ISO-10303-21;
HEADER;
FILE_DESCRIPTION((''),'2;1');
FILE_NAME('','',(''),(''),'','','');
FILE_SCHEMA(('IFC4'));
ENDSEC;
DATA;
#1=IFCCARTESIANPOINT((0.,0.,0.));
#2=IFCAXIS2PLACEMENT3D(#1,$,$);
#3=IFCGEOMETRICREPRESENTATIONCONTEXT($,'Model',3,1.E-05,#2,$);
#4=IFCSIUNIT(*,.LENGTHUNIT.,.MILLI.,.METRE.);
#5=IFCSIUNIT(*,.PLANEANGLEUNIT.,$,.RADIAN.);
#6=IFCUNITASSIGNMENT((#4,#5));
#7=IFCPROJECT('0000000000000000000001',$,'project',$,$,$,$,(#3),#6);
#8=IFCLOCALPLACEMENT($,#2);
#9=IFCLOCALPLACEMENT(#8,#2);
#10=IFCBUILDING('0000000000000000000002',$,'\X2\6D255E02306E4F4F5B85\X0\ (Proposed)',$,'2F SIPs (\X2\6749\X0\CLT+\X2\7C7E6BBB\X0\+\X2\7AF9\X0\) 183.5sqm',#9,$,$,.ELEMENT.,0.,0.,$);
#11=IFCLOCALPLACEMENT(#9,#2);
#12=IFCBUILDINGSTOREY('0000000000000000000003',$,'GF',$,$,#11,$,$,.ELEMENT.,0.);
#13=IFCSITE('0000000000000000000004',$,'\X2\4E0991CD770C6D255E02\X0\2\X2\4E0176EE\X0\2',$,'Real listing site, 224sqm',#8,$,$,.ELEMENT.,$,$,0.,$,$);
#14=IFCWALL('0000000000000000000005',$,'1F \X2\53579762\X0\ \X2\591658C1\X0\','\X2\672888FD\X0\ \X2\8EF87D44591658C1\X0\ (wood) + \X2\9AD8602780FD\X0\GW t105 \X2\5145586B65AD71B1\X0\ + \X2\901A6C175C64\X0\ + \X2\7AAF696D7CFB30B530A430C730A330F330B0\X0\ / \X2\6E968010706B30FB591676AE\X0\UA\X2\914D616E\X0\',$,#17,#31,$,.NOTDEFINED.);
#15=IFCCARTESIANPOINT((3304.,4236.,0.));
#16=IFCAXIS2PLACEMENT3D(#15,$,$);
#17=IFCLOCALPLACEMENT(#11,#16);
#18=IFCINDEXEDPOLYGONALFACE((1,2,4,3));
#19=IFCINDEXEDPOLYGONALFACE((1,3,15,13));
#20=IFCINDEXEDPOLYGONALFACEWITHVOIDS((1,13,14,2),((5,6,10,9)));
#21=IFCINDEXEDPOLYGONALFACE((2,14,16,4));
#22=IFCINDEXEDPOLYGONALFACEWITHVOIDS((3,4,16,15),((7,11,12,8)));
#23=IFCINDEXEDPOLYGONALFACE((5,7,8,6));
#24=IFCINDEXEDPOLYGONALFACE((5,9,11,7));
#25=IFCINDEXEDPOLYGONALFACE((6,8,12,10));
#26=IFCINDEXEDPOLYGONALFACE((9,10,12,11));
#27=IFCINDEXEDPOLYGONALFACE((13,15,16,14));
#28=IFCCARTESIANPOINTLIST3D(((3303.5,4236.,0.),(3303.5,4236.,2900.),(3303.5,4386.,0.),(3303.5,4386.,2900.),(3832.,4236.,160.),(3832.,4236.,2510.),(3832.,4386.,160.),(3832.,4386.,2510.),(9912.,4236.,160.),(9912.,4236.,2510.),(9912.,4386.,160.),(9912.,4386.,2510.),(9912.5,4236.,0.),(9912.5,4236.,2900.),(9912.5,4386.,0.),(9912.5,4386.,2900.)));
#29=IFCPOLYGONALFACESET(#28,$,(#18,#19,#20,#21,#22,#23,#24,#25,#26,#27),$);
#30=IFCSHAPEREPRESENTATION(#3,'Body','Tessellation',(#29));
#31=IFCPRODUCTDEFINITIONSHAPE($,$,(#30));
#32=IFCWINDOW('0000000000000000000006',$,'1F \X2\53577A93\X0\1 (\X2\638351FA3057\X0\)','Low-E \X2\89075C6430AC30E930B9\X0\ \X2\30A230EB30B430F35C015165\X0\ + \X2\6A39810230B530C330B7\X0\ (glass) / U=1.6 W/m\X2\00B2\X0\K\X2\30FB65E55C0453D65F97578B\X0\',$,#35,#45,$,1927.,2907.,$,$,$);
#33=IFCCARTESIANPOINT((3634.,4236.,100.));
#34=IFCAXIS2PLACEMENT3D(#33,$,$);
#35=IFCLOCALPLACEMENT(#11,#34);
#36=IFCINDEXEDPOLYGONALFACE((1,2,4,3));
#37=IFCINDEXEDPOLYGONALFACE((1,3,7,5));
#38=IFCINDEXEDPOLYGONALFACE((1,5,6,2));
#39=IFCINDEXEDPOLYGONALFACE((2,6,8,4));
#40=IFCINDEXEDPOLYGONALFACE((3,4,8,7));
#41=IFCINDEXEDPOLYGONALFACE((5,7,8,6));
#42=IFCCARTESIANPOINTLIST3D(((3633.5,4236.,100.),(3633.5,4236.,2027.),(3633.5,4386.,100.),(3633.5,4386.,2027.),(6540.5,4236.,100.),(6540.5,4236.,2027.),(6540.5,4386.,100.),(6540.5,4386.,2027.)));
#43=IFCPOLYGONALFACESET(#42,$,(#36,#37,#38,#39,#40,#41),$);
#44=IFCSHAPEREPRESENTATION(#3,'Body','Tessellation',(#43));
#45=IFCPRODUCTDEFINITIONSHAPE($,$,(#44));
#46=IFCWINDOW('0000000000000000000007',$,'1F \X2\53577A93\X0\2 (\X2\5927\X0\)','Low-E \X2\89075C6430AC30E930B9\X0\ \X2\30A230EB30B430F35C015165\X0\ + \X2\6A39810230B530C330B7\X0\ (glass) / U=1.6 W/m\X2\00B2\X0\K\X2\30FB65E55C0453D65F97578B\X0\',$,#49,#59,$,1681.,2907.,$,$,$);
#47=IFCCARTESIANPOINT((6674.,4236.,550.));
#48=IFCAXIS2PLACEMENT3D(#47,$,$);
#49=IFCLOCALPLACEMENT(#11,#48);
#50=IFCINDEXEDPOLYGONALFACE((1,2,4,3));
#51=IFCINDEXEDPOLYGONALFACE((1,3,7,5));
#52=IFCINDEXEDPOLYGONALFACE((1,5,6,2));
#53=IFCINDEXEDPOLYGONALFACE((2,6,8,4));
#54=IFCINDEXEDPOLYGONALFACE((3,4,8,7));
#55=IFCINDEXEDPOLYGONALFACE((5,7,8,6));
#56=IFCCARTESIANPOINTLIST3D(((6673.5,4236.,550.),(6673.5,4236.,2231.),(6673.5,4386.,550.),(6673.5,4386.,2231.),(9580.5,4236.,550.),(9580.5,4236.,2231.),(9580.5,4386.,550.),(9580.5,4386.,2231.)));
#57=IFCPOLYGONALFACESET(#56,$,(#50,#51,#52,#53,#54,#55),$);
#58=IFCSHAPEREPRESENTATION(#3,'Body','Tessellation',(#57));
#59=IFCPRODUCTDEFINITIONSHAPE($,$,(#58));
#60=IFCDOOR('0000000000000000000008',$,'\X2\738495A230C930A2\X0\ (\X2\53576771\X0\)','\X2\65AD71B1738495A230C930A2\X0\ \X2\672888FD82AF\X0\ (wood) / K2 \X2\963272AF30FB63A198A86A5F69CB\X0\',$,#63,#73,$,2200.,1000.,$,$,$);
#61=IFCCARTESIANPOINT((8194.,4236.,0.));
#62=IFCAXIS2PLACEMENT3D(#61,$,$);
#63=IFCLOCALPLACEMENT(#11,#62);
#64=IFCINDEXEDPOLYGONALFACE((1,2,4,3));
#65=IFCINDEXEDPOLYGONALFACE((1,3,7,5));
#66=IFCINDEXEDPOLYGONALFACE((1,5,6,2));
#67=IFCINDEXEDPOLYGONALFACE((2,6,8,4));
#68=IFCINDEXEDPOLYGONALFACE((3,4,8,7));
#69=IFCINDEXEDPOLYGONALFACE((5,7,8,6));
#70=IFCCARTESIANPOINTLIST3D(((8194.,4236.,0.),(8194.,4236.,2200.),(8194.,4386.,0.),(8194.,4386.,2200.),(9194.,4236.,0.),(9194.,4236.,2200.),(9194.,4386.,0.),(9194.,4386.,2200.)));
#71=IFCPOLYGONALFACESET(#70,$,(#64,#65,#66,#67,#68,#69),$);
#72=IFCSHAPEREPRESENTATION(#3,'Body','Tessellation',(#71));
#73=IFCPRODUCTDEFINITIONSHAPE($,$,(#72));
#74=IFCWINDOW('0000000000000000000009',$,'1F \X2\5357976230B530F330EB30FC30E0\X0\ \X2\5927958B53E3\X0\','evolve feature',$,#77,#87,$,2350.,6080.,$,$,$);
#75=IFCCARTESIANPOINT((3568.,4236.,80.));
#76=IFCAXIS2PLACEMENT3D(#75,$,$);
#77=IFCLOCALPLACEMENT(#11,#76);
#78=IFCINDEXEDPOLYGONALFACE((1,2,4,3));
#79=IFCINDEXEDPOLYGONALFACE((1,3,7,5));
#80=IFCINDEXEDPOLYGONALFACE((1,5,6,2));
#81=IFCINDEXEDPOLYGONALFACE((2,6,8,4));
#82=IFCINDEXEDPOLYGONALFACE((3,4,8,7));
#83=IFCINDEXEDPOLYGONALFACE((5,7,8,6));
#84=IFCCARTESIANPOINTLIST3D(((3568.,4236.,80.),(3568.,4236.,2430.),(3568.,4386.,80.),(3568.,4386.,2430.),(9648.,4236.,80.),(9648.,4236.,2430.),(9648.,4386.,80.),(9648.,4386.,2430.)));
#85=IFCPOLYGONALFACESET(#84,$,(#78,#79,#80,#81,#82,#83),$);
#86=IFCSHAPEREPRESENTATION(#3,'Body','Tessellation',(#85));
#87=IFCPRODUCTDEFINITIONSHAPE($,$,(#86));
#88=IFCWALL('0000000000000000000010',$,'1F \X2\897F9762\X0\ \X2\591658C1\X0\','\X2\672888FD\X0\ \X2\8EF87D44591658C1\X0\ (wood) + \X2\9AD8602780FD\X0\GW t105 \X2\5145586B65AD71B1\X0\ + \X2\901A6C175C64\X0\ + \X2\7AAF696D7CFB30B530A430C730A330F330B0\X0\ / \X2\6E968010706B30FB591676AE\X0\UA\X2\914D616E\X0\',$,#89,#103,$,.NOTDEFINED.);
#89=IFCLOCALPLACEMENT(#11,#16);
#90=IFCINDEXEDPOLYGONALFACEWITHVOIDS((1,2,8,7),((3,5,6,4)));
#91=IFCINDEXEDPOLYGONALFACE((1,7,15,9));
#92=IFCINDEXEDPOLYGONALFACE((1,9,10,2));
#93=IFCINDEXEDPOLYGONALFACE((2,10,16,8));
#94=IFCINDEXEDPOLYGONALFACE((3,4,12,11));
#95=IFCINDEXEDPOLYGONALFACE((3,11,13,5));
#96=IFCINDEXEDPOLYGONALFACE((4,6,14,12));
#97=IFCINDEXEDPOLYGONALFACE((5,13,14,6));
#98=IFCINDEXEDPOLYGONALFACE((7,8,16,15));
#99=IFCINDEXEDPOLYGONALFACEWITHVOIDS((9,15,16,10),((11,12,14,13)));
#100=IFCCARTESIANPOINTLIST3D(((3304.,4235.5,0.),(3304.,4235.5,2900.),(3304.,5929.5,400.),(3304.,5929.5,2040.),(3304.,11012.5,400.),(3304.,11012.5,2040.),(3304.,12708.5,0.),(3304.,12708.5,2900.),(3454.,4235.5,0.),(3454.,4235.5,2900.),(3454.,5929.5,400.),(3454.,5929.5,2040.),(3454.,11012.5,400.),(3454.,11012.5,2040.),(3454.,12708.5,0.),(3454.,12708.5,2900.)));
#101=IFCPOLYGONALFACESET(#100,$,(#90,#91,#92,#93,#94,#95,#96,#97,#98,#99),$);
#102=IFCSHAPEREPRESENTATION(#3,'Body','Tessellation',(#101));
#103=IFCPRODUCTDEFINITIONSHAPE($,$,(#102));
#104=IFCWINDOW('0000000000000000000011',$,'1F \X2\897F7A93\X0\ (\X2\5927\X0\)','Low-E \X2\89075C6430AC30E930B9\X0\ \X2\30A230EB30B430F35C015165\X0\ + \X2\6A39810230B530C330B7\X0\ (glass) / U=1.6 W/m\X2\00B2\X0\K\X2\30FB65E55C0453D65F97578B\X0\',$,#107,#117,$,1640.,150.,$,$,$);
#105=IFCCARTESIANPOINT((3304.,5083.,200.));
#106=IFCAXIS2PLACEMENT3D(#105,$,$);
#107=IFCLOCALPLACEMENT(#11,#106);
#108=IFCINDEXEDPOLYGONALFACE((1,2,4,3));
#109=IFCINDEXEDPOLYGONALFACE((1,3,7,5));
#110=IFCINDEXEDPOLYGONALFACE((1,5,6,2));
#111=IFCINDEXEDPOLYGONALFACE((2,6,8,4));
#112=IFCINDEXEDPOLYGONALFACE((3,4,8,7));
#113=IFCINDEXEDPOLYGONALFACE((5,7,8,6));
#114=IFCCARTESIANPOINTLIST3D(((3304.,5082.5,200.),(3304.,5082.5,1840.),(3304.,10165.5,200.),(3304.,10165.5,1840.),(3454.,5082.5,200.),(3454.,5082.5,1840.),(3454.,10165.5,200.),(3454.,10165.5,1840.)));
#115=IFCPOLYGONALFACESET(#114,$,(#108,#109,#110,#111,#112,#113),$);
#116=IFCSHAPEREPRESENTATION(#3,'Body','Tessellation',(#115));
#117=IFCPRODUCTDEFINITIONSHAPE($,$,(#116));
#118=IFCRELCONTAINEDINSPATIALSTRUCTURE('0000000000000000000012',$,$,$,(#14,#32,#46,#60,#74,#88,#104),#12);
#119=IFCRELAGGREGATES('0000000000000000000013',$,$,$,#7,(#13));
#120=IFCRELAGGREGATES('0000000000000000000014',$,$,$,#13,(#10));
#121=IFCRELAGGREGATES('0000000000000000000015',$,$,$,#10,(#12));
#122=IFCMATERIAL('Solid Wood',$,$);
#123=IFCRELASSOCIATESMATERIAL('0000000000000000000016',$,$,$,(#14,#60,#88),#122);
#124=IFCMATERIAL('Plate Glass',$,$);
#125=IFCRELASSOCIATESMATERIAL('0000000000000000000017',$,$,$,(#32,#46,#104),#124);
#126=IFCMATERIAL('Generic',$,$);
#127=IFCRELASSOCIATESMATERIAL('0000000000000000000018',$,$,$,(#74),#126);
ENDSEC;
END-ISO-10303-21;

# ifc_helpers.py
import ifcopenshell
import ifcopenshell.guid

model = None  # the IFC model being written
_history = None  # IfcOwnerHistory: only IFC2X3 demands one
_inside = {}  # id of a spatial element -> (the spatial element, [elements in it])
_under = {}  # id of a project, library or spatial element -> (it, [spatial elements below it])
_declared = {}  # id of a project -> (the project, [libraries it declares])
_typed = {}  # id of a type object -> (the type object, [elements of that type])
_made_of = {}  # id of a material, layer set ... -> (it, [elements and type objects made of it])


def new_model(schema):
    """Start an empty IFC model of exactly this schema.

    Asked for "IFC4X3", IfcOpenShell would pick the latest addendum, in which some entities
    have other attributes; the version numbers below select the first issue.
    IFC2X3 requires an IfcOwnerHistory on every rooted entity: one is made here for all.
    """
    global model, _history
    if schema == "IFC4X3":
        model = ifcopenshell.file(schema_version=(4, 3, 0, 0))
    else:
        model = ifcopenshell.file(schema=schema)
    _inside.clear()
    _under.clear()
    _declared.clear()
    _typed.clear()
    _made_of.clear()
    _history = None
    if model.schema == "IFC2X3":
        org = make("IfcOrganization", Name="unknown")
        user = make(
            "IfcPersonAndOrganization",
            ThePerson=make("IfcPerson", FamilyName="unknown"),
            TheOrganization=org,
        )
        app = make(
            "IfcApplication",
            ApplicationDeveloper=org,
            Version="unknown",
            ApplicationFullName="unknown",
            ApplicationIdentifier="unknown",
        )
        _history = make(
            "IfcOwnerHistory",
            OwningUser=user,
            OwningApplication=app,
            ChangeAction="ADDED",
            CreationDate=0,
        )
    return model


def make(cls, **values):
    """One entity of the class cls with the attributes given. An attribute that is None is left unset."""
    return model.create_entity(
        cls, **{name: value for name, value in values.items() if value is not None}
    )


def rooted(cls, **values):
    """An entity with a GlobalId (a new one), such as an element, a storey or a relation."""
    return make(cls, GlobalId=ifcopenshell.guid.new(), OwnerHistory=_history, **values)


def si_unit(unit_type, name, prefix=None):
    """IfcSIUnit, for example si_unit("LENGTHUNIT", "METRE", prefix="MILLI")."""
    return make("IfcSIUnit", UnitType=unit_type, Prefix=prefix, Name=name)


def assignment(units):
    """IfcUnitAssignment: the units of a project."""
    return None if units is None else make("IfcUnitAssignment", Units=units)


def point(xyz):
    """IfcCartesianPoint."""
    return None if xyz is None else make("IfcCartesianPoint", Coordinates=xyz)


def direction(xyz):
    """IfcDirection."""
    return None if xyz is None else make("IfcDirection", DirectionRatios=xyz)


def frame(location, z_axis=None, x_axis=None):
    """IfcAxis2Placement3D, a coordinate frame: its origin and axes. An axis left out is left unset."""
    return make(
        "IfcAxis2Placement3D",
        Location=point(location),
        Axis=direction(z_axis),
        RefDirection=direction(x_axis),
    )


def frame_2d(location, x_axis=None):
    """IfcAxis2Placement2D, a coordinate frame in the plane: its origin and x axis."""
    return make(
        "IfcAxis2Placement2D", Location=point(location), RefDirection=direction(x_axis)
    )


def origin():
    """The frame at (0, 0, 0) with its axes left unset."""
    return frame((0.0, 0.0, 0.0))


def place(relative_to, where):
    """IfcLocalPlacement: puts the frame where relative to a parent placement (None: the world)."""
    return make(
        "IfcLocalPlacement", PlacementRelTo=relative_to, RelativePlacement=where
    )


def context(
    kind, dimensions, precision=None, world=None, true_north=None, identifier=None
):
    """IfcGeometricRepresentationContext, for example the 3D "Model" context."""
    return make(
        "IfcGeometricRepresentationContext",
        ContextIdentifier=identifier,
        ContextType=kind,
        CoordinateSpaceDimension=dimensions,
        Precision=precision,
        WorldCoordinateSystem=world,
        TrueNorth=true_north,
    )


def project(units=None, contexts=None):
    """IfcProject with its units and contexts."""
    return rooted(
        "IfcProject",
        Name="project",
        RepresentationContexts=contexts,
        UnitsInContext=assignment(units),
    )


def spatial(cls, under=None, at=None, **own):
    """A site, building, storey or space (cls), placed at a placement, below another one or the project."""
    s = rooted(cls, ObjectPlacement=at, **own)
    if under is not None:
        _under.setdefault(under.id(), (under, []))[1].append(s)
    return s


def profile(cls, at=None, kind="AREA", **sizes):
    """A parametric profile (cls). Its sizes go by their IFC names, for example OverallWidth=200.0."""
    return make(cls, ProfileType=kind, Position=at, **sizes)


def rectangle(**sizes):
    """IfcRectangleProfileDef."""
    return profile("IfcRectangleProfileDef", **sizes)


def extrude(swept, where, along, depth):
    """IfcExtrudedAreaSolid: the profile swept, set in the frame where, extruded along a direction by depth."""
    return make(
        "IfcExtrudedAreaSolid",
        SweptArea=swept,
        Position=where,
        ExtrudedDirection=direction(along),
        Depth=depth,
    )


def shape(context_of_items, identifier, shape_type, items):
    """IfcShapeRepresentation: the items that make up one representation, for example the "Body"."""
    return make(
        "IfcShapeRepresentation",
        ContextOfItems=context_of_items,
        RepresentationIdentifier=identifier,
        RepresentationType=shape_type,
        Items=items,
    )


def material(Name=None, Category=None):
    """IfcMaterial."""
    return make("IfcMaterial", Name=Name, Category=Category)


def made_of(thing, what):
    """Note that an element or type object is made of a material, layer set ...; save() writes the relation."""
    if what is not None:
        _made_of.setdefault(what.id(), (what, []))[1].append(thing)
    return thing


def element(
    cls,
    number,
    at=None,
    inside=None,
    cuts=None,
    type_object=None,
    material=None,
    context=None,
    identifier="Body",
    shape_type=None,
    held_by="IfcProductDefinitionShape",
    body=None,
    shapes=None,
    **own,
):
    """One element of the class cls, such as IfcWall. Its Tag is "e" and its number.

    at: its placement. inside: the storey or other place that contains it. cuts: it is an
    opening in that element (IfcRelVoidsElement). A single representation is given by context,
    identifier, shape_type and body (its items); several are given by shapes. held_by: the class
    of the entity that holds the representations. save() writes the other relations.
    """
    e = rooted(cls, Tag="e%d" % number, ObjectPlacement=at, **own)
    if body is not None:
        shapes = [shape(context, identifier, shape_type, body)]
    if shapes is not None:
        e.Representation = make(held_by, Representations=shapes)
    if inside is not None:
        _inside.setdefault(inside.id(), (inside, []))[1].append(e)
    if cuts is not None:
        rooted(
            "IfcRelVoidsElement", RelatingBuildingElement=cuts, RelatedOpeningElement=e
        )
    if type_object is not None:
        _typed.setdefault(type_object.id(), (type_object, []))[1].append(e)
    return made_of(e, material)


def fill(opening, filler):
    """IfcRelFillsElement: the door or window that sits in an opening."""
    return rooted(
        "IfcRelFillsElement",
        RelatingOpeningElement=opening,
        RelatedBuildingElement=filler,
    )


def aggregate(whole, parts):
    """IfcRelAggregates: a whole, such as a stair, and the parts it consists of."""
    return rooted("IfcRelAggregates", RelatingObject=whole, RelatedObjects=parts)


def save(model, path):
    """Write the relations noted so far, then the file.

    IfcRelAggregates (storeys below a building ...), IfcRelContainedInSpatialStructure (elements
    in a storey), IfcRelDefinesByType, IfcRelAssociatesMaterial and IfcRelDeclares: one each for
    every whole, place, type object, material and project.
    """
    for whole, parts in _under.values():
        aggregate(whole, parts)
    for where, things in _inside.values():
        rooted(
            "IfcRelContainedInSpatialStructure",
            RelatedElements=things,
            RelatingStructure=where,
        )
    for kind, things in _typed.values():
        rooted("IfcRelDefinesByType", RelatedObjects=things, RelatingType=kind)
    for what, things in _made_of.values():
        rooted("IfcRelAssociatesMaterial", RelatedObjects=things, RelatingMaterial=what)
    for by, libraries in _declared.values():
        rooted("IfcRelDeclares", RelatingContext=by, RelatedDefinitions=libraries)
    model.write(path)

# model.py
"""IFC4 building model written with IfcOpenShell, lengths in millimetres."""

from ifc_helpers import new_model, si_unit, frame, frame_2d, origin, place, context, project, spatial, rectangle, extrude, material, element, fill, save


model = new_model("IFC4")

# Units and contexts
model_context = context("Model", 3, precision=1e-05, world=origin())
ifc_project = project(units=[si_unit("LENGTHUNIT", "METRE", prefix="MILLI"), si_unit("PLANEANGLEUNIT", "RADIAN")], contexts=[model_context])

# Site, building, storey
site_placement = place(None, origin())
site = spatial("IfcSite", under=ifc_project, at=site_placement, Name="三重県津市2丁目2", ObjectType="Real listing site, 224sqm", CompositionType="ELEMENT", RefElevation=0.0)
building_placement = place(site_placement, origin())
building = spatial("IfcBuilding", under=site, at=building_placement, Name="津市の住宅 (Proposed)", ObjectType="2F SIPs (杉CLT+籾殻+竹) 183.5sqm", CompositionType="ELEMENT", ElevationOfRefHeight=0.0, ElevationOfTerrain=0.0)
storey_placement = place(building_placement, origin())
storey = spatial("IfcBuildingStorey", under=building, at=storey_placement, Name="GF", CompositionType="ELEMENT", Elevation=0.0)

# Shared definitions
ifc_material_1 = material(Name="Solid Wood")
ifc_material_2 = material(Name="Generic")

# Wall, openings, windows, door
wall_1_placement = place(storey_placement, frame((3304.0, 4236.0, 0.0)))
wall_1 = element("IfcWall", 1, at=wall_1_placement, inside=storey, material=ifc_material_1, Name="1F 南面 外壁", Description="木製 軸組外壁 (wood) + 高性能GW t105 充填断熱 + 通気層 + 窯業系サイディング / 準耐火・外皮UA配慮", PredefinedType="NOTDEFINED", context=model_context, shape_type="SweptSolid", body=[
    extrude(rectangle(XDim=6609.0, YDim=150.0, at=frame_2d((3304.0, 75.0))), frame((3304.0, 4236.0, 0.0)), (0.0, 0.0, 1.0), 2900.0),
])
opening_1_placement = place(storey_placement, frame((3634.0, 4236.0, 100.0)))
opening_1 = element("IfcOpeningElement", 2, at=opening_1_placement, cuts=wall_1, PredefinedType="NOTDEFINED", context=model_context, shape_type="SweptSolid", body=[
    extrude(rectangle(XDim=2907.0, YDim=150.0, at=frame_2d((1453.0, 75.0))), frame((3634.0, 4236.0, 100.0)), (0.0, 0.0, 1.0), 1927.0),
])
opening_2_placement = place(storey_placement, frame((6674.0, 4236.0, 550.0)))
opening_2 = element("IfcOpeningElement", 3, at=opening_2_placement, cuts=wall_1, PredefinedType="NOTDEFINED", context=model_context, shape_type="SweptSolid", body=[
    extrude(rectangle(XDim=2907.0, YDim=150.0, at=frame_2d((1453.0, 75.0))), frame((6674.0, 4236.0, 550.0)), (0.0, 0.0, 1.0), 1681.0),
])
opening_3_placement = place(storey_placement, frame((8194.0, 4236.0, 0.0)))
opening_3 = element("IfcOpeningElement", 4, at=opening_3_placement, cuts=wall_1, PredefinedType="NOTDEFINED", context=model_context, shape_type="SweptSolid", body=[
    extrude(rectangle(XDim=1000.0, YDim=150.0, at=frame_2d((500.0, 75.0))), frame((8194.0, 4236.0, 0.0)), (0.0, 0.0, 1.0), 2200.0),
])
opening_4_placement = place(storey_placement, frame((3568.0, 4236.0, 80.0)))
opening_4 = element("IfcOpeningElement", 5, at=opening_4_placement, cuts=wall_1, PredefinedType="NOTDEFINED", context=model_context, shape_type="SweptSolid", body=[
    extrude(rectangle(XDim=6080.0, YDim=150.0, at=frame_2d((3040.0, 75.0))), frame((3568.0, 4236.0, 80.0)), (0.0, 0.0, 1.0), 2350.0),
])
ifc_material_3 = material(Name="Plate Glass")
window_1_placement = place(storey_placement, frame((3634.0, 4236.0, 100.0)))
window_1 = element("IfcWindow", 6, at=window_1_placement, inside=storey, material=ifc_material_3, Name="1F 南窓1 (掃出し)", Description="Low-E 複層ガラス アルゴン封入 + 樹脂サッシ (glass) / U=1.6 W/m²K・日射取得型", OverallHeight=1927.0, OverallWidth=2907.0, context=model_context, shape_type="SweptSolid", body=[
    extrude(rectangle(XDim=2907.0, YDim=150.0, at=frame_2d((1453.0, 75.0))), frame((3634.0, 4236.0, 100.0)), (0.0, 0.0, 1.0), 1927.0),
])
fill(opening_1, window_1)
window_2_placement = place(storey_placement, frame((6674.0, 4236.0, 550.0)))
window_2 = element("IfcWindow", 7, at=window_2_placement, inside=storey, material=ifc_material_3, Name="1F 南窓2 (大)", Description="Low-E 複層ガラス アルゴン封入 + 樹脂サッシ (glass) / U=1.6 W/m²K・日射取得型", OverallHeight=1681.0, OverallWidth=2907.0, context=model_context, shape_type="SweptSolid", body=[
    extrude(rectangle(XDim=2907.0, YDim=150.0, at=frame_2d((1453.0, 75.0))), frame((6674.0, 4236.0, 550.0)), (0.0, 0.0, 1.0), 1681.0),
])
fill(opening_2, window_2)
door_placement = place(storey_placement, frame((8194.0, 4236.0, 0.0)))
door = element("IfcDoor", 8, at=door_placement, inside=storey, material=ifc_material_1, Name="玄関ドア (南東)", Description="断熱玄関ドア 木製芯 (wood) / K2 防犯・採風機構", OverallHeight=2200.0, OverallWidth=1000.0, context=model_context, shape_type="SweptSolid", body=[
    extrude(rectangle(XDim=1000.0, YDim=150.0, at=frame_2d((500.0, 75.0))), frame((8194.0, 4236.0, 0.0)), (0.0, 0.0, 1.0), 2200.0),
])
fill(opening_3, door)
window_3_placement = place(storey_placement, frame((3568.0, 4236.0, 80.0)))
window_3 = element("IfcWindow", 9, at=window_3_placement, inside=storey, material=ifc_material_2, Name="1F 南面サンルーム 大開口", Description="evolve feature", OverallHeight=2350.0, OverallWidth=6080.0, context=model_context, shape_type="SweptSolid", body=[
    extrude(rectangle(XDim=6080.0, YDim=150.0, at=frame_2d((3040.0, 75.0))), frame((3568.0, 4236.0, 80.0)), (0.0, 0.0, 1.0), 2350.0),
])
fill(opening_4, window_3)

# Wall, opening, window
wall_2_placement = place(storey_placement, frame((3304.0, 4236.0, 0.0)))
wall_2 = element("IfcWall", 10, at=wall_2_placement, inside=storey, material=ifc_material_1, Name="1F 西面 外壁", Description="木製 軸組外壁 (wood) + 高性能GW t105 充填断熱 + 通気層 + 窯業系サイディング / 準耐火・外皮UA配慮", PredefinedType="NOTDEFINED", context=model_context, shape_type="SweptSolid", body=[
    extrude(rectangle(XDim=150.0, YDim=8473.0, at=frame_2d((75.0, 4236.0))), frame((3304.0, 4236.0, 0.0)), (0.0, 0.0, 1.0), 2900.0),
])
opening_5_placement = place(storey_placement, frame((3304.0, 5083.0, 200.0)))
opening_5 = element("IfcOpeningElement", 11, at=opening_5_placement, cuts=wall_2, PredefinedType="NOTDEFINED", context=model_context, shape_type="SweptSolid", body=[
    extrude(rectangle(XDim=150.0, YDim=5083.0, at=frame_2d((75.0, 2541.0))), frame((3304.0, 5083.0, 200.0)), (0.0, 0.0, 1.0), 1640.0),
])
window_4_placement = place(storey_placement, frame((3304.0, 5083.0, 200.0)))
window_4 = element("IfcWindow", 12, at=window_4_placement, inside=storey, material=ifc_material_3, Name="1F 西窓 (大)", Description="Low-E 複層ガラス アルゴン封入 + 樹脂サッシ (glass) / U=1.6 W/m²K・日射取得型", OverallHeight=1640.0, OverallWidth=150.0, context=model_context, shape_type="SweptSolid", body=[
    extrude(rectangle(XDim=150.0, YDim=5083.0, at=frame_2d((75.0, 2541.0))), frame((3304.0, 5083.0, 200.0)), (0.0, 0.0, 1.0), 1640.0),
])
fill(opening_5, window_4)

save(model, "model.ifc")
